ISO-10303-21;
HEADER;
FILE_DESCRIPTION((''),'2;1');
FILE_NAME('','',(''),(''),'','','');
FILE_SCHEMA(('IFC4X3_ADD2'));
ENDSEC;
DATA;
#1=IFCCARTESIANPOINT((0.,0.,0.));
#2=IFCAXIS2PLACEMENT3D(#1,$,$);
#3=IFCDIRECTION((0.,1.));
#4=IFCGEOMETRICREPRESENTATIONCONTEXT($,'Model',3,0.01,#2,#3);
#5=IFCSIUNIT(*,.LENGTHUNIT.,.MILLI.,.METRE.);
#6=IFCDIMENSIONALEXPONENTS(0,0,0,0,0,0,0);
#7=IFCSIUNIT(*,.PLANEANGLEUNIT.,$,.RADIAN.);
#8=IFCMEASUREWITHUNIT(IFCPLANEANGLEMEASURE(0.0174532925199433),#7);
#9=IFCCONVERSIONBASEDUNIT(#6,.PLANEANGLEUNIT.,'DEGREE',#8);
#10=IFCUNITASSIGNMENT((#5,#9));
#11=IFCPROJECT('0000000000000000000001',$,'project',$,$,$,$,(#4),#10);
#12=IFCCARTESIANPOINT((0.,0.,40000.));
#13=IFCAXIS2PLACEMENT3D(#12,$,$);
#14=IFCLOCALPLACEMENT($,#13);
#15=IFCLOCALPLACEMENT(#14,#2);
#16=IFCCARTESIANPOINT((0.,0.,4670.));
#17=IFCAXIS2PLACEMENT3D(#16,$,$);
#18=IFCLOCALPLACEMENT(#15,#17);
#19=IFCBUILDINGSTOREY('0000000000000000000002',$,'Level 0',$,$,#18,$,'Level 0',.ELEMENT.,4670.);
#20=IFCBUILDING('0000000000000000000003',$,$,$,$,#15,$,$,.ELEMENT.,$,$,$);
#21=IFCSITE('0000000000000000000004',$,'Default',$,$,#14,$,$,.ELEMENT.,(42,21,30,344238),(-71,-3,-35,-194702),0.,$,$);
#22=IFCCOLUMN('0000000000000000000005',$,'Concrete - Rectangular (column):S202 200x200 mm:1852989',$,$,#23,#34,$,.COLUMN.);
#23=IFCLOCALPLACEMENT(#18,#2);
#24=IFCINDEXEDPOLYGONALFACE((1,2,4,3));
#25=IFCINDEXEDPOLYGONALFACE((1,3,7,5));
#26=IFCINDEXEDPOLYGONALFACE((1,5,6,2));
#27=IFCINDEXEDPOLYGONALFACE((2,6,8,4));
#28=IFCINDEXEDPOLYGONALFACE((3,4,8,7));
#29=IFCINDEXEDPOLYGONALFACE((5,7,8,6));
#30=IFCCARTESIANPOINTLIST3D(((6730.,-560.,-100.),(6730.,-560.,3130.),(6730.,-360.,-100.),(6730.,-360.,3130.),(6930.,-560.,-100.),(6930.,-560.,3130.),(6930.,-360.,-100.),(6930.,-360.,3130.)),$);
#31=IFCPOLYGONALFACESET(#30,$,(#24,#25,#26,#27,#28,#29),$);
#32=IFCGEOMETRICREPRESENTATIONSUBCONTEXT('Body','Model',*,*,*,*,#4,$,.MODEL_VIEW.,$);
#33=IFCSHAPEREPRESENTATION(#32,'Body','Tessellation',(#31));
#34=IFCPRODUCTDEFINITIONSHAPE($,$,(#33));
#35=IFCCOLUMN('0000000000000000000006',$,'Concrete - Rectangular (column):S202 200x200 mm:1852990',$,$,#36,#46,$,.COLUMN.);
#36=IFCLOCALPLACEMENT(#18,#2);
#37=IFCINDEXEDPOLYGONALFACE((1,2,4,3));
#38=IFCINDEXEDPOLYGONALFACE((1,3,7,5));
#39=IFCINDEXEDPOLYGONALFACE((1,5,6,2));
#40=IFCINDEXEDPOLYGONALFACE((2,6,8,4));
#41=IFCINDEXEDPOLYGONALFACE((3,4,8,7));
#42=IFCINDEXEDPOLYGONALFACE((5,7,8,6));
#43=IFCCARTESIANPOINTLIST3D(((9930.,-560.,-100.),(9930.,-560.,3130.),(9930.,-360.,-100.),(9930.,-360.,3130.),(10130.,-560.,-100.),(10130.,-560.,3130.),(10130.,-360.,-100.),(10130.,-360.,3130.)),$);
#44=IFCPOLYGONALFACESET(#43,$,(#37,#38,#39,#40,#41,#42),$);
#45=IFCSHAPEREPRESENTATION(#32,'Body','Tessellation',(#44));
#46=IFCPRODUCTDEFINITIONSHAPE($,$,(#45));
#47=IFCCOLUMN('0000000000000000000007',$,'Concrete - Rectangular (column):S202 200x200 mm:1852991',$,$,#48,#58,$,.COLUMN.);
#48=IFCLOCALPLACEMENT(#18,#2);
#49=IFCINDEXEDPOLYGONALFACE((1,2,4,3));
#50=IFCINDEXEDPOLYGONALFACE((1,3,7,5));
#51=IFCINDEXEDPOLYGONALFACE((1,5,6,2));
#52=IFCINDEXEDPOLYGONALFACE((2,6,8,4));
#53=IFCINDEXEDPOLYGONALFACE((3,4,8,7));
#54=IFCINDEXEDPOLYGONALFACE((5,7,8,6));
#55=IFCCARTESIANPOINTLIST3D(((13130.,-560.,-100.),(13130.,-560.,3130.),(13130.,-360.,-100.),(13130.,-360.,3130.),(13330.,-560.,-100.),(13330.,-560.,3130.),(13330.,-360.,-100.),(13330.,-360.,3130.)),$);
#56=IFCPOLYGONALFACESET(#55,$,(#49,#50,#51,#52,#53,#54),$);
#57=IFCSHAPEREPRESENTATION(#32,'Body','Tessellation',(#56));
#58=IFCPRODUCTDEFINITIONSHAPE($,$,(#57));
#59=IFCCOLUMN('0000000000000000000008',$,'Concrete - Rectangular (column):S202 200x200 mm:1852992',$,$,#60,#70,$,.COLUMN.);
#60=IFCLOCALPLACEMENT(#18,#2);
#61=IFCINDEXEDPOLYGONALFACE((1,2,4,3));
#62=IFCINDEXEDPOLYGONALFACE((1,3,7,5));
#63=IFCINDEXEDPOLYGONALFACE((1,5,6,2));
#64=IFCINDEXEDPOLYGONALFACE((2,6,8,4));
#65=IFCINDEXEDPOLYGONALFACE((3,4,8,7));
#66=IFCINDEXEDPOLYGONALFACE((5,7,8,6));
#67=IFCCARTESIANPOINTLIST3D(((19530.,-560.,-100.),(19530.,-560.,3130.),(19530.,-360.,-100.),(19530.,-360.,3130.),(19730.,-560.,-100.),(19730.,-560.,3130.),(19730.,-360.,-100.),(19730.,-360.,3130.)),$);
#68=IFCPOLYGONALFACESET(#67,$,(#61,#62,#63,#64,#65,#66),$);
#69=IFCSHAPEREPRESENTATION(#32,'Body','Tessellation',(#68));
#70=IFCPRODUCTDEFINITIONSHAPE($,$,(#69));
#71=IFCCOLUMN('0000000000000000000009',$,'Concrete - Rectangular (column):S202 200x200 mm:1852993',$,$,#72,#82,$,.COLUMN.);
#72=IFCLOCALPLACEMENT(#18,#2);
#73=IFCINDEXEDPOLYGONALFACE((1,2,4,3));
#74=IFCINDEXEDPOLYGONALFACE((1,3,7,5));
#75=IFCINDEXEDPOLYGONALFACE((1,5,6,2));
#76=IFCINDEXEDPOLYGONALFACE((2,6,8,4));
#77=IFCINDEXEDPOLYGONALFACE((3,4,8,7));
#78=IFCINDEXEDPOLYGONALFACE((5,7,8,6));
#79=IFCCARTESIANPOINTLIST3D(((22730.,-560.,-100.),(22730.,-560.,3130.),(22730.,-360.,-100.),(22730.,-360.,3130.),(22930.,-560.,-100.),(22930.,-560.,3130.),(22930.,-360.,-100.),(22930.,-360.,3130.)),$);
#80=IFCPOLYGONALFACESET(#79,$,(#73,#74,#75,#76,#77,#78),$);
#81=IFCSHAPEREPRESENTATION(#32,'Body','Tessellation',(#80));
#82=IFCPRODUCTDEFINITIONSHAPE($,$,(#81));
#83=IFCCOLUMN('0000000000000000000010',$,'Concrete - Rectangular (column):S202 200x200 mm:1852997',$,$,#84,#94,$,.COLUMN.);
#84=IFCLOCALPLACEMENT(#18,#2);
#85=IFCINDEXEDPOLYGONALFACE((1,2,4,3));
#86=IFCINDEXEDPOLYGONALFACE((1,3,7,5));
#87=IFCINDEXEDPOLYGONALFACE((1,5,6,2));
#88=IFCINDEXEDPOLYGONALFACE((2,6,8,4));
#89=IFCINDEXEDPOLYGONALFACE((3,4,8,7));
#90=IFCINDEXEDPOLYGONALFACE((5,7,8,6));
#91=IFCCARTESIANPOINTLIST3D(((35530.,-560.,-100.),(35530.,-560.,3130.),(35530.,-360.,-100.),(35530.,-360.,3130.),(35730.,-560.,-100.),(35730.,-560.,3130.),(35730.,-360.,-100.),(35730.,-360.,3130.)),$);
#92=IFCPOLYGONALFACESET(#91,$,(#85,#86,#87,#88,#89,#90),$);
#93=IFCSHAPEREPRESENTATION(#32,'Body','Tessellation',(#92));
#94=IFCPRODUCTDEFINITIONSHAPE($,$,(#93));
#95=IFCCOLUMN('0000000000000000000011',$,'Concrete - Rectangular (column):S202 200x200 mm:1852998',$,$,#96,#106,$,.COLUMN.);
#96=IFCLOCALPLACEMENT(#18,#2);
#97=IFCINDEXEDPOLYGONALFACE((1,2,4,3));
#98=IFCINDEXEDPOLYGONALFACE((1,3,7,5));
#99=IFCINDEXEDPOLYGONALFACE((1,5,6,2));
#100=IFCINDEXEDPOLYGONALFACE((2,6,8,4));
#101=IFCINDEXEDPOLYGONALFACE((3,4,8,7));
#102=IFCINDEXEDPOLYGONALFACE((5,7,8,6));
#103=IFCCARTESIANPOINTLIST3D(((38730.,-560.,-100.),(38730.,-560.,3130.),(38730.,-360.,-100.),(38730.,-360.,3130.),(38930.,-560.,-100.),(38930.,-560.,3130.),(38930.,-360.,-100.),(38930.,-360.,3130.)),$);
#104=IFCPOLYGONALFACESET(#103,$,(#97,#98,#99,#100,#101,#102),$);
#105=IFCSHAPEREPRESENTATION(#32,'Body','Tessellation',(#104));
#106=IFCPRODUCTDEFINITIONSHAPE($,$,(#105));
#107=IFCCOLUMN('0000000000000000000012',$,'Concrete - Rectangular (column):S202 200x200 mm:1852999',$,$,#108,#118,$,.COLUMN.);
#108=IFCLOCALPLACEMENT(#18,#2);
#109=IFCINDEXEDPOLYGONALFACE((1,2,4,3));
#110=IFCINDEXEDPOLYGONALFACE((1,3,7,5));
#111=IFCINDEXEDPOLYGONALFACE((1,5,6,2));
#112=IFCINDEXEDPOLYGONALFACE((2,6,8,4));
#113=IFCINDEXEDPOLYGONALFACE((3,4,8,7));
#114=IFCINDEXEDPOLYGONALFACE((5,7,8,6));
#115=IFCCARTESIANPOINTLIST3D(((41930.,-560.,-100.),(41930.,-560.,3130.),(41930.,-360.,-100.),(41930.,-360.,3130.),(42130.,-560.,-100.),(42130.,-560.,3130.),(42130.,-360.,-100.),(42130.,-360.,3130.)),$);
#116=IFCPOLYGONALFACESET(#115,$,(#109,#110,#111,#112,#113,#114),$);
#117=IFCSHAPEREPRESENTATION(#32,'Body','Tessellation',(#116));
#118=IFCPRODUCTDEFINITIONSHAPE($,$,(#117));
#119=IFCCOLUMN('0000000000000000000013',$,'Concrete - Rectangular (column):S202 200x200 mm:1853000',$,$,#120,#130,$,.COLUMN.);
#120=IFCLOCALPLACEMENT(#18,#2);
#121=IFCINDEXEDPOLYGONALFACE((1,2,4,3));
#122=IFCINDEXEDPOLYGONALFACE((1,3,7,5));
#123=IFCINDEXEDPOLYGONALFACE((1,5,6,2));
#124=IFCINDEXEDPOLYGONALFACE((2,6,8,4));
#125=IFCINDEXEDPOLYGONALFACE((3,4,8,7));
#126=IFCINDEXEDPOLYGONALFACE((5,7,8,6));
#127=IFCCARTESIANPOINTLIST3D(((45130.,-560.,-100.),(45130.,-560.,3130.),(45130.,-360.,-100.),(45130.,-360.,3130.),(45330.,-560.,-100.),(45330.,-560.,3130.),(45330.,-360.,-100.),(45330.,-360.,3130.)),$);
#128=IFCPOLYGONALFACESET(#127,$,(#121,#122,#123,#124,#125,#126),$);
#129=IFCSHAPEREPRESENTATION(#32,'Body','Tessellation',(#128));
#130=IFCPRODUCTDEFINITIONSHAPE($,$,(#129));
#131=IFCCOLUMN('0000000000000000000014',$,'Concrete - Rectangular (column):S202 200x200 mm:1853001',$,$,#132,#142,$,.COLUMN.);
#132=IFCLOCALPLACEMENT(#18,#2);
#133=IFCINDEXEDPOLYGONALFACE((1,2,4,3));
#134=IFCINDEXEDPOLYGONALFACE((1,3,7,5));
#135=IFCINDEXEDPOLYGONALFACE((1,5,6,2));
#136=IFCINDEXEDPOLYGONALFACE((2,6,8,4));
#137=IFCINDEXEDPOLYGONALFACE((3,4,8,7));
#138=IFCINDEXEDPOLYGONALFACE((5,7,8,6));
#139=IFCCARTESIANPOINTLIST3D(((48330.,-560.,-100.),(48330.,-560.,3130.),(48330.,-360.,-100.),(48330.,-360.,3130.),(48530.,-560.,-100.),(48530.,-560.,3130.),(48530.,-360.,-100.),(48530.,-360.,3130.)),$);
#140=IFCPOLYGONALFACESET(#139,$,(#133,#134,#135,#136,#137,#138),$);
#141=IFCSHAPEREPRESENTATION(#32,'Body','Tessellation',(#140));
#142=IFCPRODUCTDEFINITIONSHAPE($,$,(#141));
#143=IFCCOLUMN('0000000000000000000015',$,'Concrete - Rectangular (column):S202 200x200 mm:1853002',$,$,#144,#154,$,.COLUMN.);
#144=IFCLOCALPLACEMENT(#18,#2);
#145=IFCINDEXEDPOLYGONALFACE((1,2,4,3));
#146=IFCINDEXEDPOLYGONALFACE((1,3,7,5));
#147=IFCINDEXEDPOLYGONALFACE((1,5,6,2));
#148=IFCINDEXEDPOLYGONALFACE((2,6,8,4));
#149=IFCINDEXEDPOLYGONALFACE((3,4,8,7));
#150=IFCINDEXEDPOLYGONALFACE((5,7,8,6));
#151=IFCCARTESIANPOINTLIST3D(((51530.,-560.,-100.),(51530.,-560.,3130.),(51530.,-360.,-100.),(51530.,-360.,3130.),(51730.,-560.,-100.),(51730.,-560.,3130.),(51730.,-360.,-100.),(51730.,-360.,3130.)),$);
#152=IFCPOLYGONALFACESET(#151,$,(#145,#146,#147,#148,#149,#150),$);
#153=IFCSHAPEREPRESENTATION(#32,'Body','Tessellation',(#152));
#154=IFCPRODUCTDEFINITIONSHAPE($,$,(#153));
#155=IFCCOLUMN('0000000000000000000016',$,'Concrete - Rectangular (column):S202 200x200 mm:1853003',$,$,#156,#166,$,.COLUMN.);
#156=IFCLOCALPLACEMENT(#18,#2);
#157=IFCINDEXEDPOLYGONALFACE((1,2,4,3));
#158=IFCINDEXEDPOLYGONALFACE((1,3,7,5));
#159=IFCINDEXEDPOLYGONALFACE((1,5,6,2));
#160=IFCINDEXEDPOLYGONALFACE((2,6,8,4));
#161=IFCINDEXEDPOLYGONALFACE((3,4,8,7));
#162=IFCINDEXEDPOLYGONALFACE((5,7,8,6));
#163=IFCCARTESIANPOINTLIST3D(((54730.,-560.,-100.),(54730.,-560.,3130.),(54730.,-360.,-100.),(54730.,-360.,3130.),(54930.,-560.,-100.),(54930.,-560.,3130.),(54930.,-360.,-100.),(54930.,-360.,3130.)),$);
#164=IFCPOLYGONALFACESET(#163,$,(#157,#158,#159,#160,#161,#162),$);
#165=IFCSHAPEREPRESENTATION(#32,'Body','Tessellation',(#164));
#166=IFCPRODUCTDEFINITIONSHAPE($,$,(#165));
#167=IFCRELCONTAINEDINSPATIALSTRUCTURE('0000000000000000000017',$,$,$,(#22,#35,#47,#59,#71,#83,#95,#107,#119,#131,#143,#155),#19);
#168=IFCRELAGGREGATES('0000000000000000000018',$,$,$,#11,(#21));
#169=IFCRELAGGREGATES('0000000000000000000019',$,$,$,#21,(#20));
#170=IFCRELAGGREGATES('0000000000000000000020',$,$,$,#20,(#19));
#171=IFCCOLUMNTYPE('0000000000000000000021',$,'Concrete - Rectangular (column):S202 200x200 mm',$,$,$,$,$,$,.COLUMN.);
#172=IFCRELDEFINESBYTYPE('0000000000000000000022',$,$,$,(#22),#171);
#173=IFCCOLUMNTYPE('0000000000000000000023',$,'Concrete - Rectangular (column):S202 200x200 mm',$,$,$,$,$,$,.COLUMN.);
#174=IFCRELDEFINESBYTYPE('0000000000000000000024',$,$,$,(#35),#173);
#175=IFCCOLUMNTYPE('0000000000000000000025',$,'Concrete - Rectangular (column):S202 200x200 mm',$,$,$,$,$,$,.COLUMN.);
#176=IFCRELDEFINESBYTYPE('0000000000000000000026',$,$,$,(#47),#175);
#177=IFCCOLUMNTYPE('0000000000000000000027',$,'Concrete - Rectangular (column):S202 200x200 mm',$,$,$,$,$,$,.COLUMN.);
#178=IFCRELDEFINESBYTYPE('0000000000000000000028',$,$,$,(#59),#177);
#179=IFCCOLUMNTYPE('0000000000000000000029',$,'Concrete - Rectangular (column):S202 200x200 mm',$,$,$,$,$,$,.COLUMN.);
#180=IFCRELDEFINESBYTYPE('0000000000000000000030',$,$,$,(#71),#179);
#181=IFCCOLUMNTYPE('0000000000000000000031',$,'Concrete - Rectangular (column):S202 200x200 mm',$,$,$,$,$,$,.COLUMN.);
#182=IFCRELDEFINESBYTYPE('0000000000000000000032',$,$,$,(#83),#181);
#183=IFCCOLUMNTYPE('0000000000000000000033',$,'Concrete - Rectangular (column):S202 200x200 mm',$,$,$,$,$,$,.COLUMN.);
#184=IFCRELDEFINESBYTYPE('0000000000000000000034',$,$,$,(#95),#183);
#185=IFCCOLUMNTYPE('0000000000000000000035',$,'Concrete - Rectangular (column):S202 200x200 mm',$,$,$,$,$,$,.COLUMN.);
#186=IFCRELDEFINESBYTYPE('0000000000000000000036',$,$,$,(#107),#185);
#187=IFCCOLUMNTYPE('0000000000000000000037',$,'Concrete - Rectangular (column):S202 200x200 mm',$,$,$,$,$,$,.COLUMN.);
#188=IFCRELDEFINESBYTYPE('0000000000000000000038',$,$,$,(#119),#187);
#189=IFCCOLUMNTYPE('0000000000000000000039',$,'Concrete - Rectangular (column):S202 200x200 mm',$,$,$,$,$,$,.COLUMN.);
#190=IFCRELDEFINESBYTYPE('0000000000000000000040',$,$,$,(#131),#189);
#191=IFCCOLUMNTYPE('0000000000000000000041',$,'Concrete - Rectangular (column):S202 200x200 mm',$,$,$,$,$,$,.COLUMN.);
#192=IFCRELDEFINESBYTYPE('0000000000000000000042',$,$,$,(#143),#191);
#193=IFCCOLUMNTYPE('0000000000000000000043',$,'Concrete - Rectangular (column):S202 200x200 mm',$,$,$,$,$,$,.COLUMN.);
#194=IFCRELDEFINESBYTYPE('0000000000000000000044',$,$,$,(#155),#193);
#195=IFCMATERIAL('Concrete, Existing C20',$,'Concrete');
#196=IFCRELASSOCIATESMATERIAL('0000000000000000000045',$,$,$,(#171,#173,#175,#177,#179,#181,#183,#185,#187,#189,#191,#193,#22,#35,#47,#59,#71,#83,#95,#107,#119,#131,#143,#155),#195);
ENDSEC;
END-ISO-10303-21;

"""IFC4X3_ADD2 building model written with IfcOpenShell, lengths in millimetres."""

from ifc_helpers import new_model, entity, si_unit, converted_unit, direction, frame, frame_2d, origin, place, context, subcontext, project, spatial, rectangle, extrude, source, transform, mapped, material, material_profile, profile_set, profile_usage, type_object, type_shapes, element, save


model = new_model("IFC4X3_ADD2")

# Units and contexts
model_context = context("Model", 3, precision=0.01, world=origin(), true_north=direction((0.0, 1.0)))
body_context = subcontext(model_context, "Body", "Model", "MODEL_VIEW")
ifc_project = project(units=[si_unit("LENGTHUNIT", "METRE", prefix="MILLI"), converted_unit("PLANEANGLEUNIT", "DEGREE", entity("IfcPlaneAngleMeasure", 0.0174532925199433), si_unit("PLANEANGLEUNIT", "RADIAN"), dimensions=[0, 0, 0, 0, 0, 0, 0])], contexts=[model_context])

# Site, building, storey
site_placement = place(None, frame((0.0, 0.0, 40000.0)))
site = spatial("IfcSite", under=ifc_project, at=site_placement, Name="Default", CompositionType="ELEMENT", RefLatitude=(42, 21, 30, 344238), RefLongitude=(-71, -3, -35, -194702), RefElevation=0.0)
building_placement = place(site_placement, origin())
building = spatial("IfcBuilding", under=site, at=building_placement, CompositionType="ELEMENT")
storey_placement = place(building_placement, frame((0.0, 0.0, 4670.0)))
storey = spatial("IfcBuildingStorey", under=building, at=storey_placement, Name="Level 0", LongName="Level 0", CompositionType="ELEMENT", Elevation=4670.0)

# Columns
ifc_material = material(Name="Concrete, Existing C20", Category="Concrete")
ifc_material_profile_1 = material_profile(ifc_material, rectangle(XDim=200.0, YDim=200.0, at=frame_2d((0.0, 0.0), x_axis=(1.0, 0.0))), Name="S202 200x200 mm")
ifc_profile_set_1 = profile_set([ifc_material_profile_1], Name="S202 200x200 mm")
ifc_profile_usage_1 = profile_usage(ifc_profile_set_1)
column_type_1 = type_object("IfcColumnType", Name="Concrete - Rectangular (column):S202 200x200 mm", PredefinedType="COLUMN", material=ifc_profile_set_1)
shared_shape_1 = source(origin(), body_context, "Body", "SweptSolid", [
    extrude(rectangle(XDim=200.0, YDim=200.0, at=frame_2d((0.0, 0.0), x_axis=(1.0, 0.0))), frame((6830.0, -460.0, 4570.0), z_axis=(0.0, 0.0, 1.0), x_axis=(0.0, 1.0, 0.0)), (0.0, 0.0, 1.0), 3230.0),
])
type_shapes(column_type_1, [shared_shape_1])
column_1_placement = place(storey_placement, frame((0.0, 0.0, -4670.0)))
element("IfcColumn", 1, at=column_1_placement, inside=storey, type_object=column_type_1, material=ifc_profile_usage_1, Name="Concrete - Rectangular (column):S202 200x200 mm:1852989", PredefinedType="COLUMN", context=body_context, shape_type="MappedRepresentation", body=[
    mapped(shared_shape_1, transform((0.0, 0.0, 0.0), scale=1.0)),
])
column_type_2 = type_object("IfcColumnType", Name="Concrete - Rectangular (column):S202 200x200 mm", PredefinedType="COLUMN", material=ifc_profile_set_1)
shared_shape_2 = source(origin(), body_context, "Body", "SweptSolid", [
    extrude(rectangle(XDim=200.0, YDim=200.0, at=frame_2d((0.0, 0.0), x_axis=(1.0, 0.0))), frame((10030.0, -460.0, 4570.0), z_axis=(0.0, 0.0, 1.0), x_axis=(0.0, 1.0, 0.0)), (0.0, 0.0, 1.0), 3230.0),
])
type_shapes(column_type_2, [shared_shape_2])
column_2_placement = place(storey_placement, frame((0.0, 0.0, -4670.0)))
element("IfcColumn", 2, at=column_2_placement, inside=storey, type_object=column_type_2, material=ifc_profile_usage_1, Name="Concrete - Rectangular (column):S202 200x200 mm:1852990", PredefinedType="COLUMN", context=body_context, shape_type="MappedRepresentation", body=[
    mapped(shared_shape_2, transform((0.0, 0.0, 0.0), scale=1.0)),
])
column_type_3 = type_object("IfcColumnType", Name="Concrete - Rectangular (column):S202 200x200 mm", PredefinedType="COLUMN", material=ifc_profile_set_1)
shared_shape_3 = source(origin(), body_context, "Body", "SweptSolid", [
    extrude(rectangle(XDim=200.0, YDim=200.0, at=frame_2d((0.0, 0.0), x_axis=(1.0, 0.0))), frame((13230.0, -460.0, 4570.0), z_axis=(0.0, 0.0, 1.0), x_axis=(0.0, 1.0, 0.0)), (0.0, 0.0, 1.0), 3230.0),
])
type_shapes(column_type_3, [shared_shape_3])
column_3_placement = place(storey_placement, frame((0.0, 0.0, -4670.0)))
element("IfcColumn", 3, at=column_3_placement, inside=storey, type_object=column_type_3, material=ifc_profile_usage_1, Name="Concrete - Rectangular (column):S202 200x200 mm:1852991", PredefinedType="COLUMN", context=body_context, shape_type="MappedRepresentation", body=[
    mapped(shared_shape_3, transform((0.0, 0.0, 0.0), scale=1.0)),
])
column_type_4 = type_object("IfcColumnType", Name="Concrete - Rectangular (column):S202 200x200 mm", PredefinedType="COLUMN", material=ifc_profile_set_1)
shared_shape_4 = source(origin(), body_context, "Body", "SweptSolid", [
    extrude(rectangle(XDim=200.0, YDim=200.0, at=frame_2d((0.0, 0.0), x_axis=(1.0, 0.0))), frame((19630.0, -460.0, 4570.0), z_axis=(0.0, 0.0, 1.0), x_axis=(0.0, 1.0, 0.0)), (0.0, 0.0, 1.0), 3230.0),
])
type_shapes(column_type_4, [shared_shape_4])
column_4_placement = place(storey_placement, frame((0.0, 0.0, -4670.0)))
element("IfcColumn", 4, at=column_4_placement, inside=storey, type_object=column_type_4, material=ifc_profile_usage_1, Name="Concrete - Rectangular (column):S202 200x200 mm:1852992", PredefinedType="COLUMN", context=body_context, shape_type="MappedRepresentation", body=[
    mapped(shared_shape_4, transform((0.0, 0.0, 0.0), scale=1.0)),
])
column_type_5 = type_object("IfcColumnType", Name="Concrete - Rectangular (column):S202 200x200 mm", PredefinedType="COLUMN", material=ifc_profile_set_1)
shared_shape_5 = source(origin(), body_context, "Body", "SweptSolid", [
    extrude(rectangle(XDim=200.0, YDim=200.0, at=frame_2d((0.0, 0.0), x_axis=(1.0, 0.0))), frame((22830.0, -460.0, 4570.0), z_axis=(0.0, 0.0, 1.0), x_axis=(0.0, 1.0, 0.0)), (0.0, 0.0, 1.0), 3230.0),
])
type_shapes(column_type_5, [shared_shape_5])
column_5_placement = place(storey_placement, frame((0.0, 0.0, -4670.0)))
element("IfcColumn", 5, at=column_5_placement, inside=storey, type_object=column_type_5, material=ifc_profile_usage_1, Name="Concrete - Rectangular (column):S202 200x200 mm:1852993", PredefinedType="COLUMN", context=body_context, shape_type="MappedRepresentation", body=[
    mapped(shared_shape_5, transform((0.0, 0.0, 0.0), scale=1.0)),
])
column_type_6 = type_object("IfcColumnType", Name="Concrete - Rectangular (column):S202 200x200 mm", PredefinedType="COLUMN", material=ifc_profile_set_1)
shared_shape_6 = source(origin(), body_context, "Body", "SweptSolid", [
    extrude(rectangle(XDim=200.0, YDim=200.0, at=frame_2d((0.0, 0.0), x_axis=(1.0, 0.0))), frame((35630.0, -460.0, 4570.0), z_axis=(0.0, 0.0, 1.0), x_axis=(0.0, 1.0, 0.0)), (0.0, 0.0, 1.0), 3230.0),
])
type_shapes(column_type_6, [shared_shape_6])
column_6_placement = place(storey_placement, frame((0.0, 0.0, -4670.0)))
element("IfcColumn", 6, at=column_6_placement, inside=storey, type_object=column_type_6, material=ifc_profile_usage_1, Name="Concrete - Rectangular (column):S202 200x200 mm:1852997", PredefinedType="COLUMN", context=body_context, shape_type="MappedRepresentation", body=[
    mapped(shared_shape_6, transform((0.0, 0.0, 0.0), scale=1.0)),
])
column_type_7 = type_object("IfcColumnType", Name="Concrete - Rectangular (column):S202 200x200 mm", PredefinedType="COLUMN", material=ifc_profile_set_1)
shared_shape_7 = source(origin(), body_context, "Body", "SweptSolid", [
    extrude(rectangle(XDim=200.0, YDim=200.0, at=frame_2d((0.0, 0.0), x_axis=(1.0, 0.0))), frame((38830.0, -460.0, 4570.0), z_axis=(0.0, 0.0, 1.0), x_axis=(0.0, 1.0, 0.0)), (0.0, 0.0, 1.0), 3230.0),
])
type_shapes(column_type_7, [shared_shape_7])
column_7_placement = place(storey_placement, frame((0.0, 0.0, -4670.0)))
element("IfcColumn", 7, at=column_7_placement, inside=storey, type_object=column_type_7, material=ifc_profile_usage_1, Name="Concrete - Rectangular (column):S202 200x200 mm:1852998", PredefinedType="COLUMN", context=body_context, shape_type="MappedRepresentation", body=[
    mapped(shared_shape_7, transform((0.0, 0.0, 0.0), scale=1.0)),
])
column_type_8 = type_object("IfcColumnType", Name="Concrete - Rectangular (column):S202 200x200 mm", PredefinedType="COLUMN", material=ifc_profile_set_1)
shared_shape_8 = source(origin(), body_context, "Body", "SweptSolid", [
    extrude(rectangle(XDim=200.0, YDim=200.0, at=frame_2d((0.0, 0.0), x_axis=(1.0, 0.0))), frame((42030.0, -460.0, 4570.0), z_axis=(0.0, 0.0, 1.0), x_axis=(0.0, 1.0, 0.0)), (0.0, 0.0, 1.0), 3230.0),
])
type_shapes(column_type_8, [shared_shape_8])
column_8_placement = place(storey_placement, frame((0.0, 0.0, -4670.0)))
element("IfcColumn", 8, at=column_8_placement, inside=storey, type_object=column_type_8, material=ifc_profile_usage_1, Name="Concrete - Rectangular (column):S202 200x200 mm:1852999", PredefinedType="COLUMN", context=body_context, shape_type="MappedRepresentation", body=[
    mapped(shared_shape_8, transform((0.0, 0.0, 0.0), scale=1.0)),
])
column_type_9 = type_object("IfcColumnType", Name="Concrete - Rectangular (column):S202 200x200 mm", PredefinedType="COLUMN", material=ifc_profile_set_1)
shared_shape_9 = source(origin(), body_context, "Body", "SweptSolid", [
    extrude(rectangle(XDim=200.0, YDim=200.0, at=frame_2d((0.0, 0.0), x_axis=(1.0, 0.0))), frame((45230.0, -460.0, 4570.0), z_axis=(0.0, 0.0, 1.0), x_axis=(0.0, 1.0, 0.0)), (0.0, 0.0, 1.0), 3230.0),
])
type_shapes(column_type_9, [shared_shape_9])
column_9_placement = place(storey_placement, frame((0.0, 0.0, -4670.0)))
element("IfcColumn", 9, at=column_9_placement, inside=storey, type_object=column_type_9, material=ifc_profile_usage_1, Name="Concrete - Rectangular (column):S202 200x200 mm:1853000", PredefinedType="COLUMN", context=body_context, shape_type="MappedRepresentation", body=[
    mapped(shared_shape_9, transform((0.0, 0.0, 0.0), scale=1.0)),
])
column_type_10 = type_object("IfcColumnType", Name="Concrete - Rectangular (column):S202 200x200 mm", PredefinedType="COLUMN", material=ifc_profile_set_1)
shared_shape_10 = source(origin(), body_context, "Body", "SweptSolid", [
    extrude(rectangle(XDim=200.0, YDim=200.0, at=frame_2d((0.0, 0.0), x_axis=(1.0, 0.0))), frame((48430.0, -460.0, 4570.0), z_axis=(0.0, 0.0, 1.0), x_axis=(0.0, 1.0, 0.0)), (0.0, 0.0, 1.0), 3230.0),
])
type_shapes(column_type_10, [shared_shape_10])
column_10_placement = place(storey_placement, frame((0.0, 0.0, -4670.0)))
element("IfcColumn", 10, at=column_10_placement, inside=storey, type_object=column_type_10, material=ifc_profile_usage_1, Name="Concrete - Rectangular (column):S202 200x200 mm:1853001", PredefinedType="COLUMN", context=body_context, shape_type="MappedRepresentation", body=[
    mapped(shared_shape_10, transform((0.0, 0.0, 0.0), scale=1.0)),
])
column_type_11 = type_object("IfcColumnType", Name="Concrete - Rectangular (column):S202 200x200 mm", PredefinedType="COLUMN", material=ifc_profile_set_1)
shared_shape_11 = source(origin(), body_context, "Body", "SweptSolid", [
    extrude(rectangle(XDim=200.0, YDim=200.0, at=frame_2d((0.0, 0.0), x_axis=(1.0, 0.0))), frame((51630.0, -460.0, 4570.0), z_axis=(0.0, 0.0, 1.0), x_axis=(0.0, 1.0, 0.0)), (0.0, 0.0, 1.0), 3230.0),
])
type_shapes(column_type_11, [shared_shape_11])
column_11_placement = place(storey_placement, frame((0.0, 0.0, -4670.0)))
element("IfcColumn", 11, at=column_11_placement, inside=storey, type_object=column_type_11, material=ifc_profile_usage_1, Name="Concrete - Rectangular (column):S202 200x200 mm:1853002", PredefinedType="COLUMN", context=body_context, shape_type="MappedRepresentation", body=[
    mapped(shared_shape_11, transform((0.0, 0.0, 0.0), scale=1.0)),
])
column_type_12 = type_object("IfcColumnType", Name="Concrete - Rectangular (column):S202 200x200 mm", PredefinedType="COLUMN", material=ifc_profile_set_1)
shared_shape_12 = source(origin(), body_context, "Body", "SweptSolid", [
    extrude(rectangle(XDim=200.0, YDim=200.0, at=frame_2d((0.0, 0.0), x_axis=(1.0, 0.0))), frame((54830.0, -460.0, 4570.0), z_axis=(0.0, 0.0, 1.0), x_axis=(0.0, 1.0, 0.0)), (0.0, 0.0, 1.0), 3230.0),
])
type_shapes(column_type_12, [shared_shape_12])
column_12_placement = place(storey_placement, frame((0.0, 0.0, -4670.0)))
element("IfcColumn", 12, at=column_12_placement, inside=storey, type_object=column_type_12, material=ifc_profile_usage_1, Name="Concrete - Rectangular (column):S202 200x200 mm:1853003", PredefinedType="COLUMN", context=body_context, shape_type="MappedRepresentation", body=[
    mapped(shared_shape_12, transform((0.0, 0.0, 0.0), scale=1.0)),
])

save(model, "model.ifc")
